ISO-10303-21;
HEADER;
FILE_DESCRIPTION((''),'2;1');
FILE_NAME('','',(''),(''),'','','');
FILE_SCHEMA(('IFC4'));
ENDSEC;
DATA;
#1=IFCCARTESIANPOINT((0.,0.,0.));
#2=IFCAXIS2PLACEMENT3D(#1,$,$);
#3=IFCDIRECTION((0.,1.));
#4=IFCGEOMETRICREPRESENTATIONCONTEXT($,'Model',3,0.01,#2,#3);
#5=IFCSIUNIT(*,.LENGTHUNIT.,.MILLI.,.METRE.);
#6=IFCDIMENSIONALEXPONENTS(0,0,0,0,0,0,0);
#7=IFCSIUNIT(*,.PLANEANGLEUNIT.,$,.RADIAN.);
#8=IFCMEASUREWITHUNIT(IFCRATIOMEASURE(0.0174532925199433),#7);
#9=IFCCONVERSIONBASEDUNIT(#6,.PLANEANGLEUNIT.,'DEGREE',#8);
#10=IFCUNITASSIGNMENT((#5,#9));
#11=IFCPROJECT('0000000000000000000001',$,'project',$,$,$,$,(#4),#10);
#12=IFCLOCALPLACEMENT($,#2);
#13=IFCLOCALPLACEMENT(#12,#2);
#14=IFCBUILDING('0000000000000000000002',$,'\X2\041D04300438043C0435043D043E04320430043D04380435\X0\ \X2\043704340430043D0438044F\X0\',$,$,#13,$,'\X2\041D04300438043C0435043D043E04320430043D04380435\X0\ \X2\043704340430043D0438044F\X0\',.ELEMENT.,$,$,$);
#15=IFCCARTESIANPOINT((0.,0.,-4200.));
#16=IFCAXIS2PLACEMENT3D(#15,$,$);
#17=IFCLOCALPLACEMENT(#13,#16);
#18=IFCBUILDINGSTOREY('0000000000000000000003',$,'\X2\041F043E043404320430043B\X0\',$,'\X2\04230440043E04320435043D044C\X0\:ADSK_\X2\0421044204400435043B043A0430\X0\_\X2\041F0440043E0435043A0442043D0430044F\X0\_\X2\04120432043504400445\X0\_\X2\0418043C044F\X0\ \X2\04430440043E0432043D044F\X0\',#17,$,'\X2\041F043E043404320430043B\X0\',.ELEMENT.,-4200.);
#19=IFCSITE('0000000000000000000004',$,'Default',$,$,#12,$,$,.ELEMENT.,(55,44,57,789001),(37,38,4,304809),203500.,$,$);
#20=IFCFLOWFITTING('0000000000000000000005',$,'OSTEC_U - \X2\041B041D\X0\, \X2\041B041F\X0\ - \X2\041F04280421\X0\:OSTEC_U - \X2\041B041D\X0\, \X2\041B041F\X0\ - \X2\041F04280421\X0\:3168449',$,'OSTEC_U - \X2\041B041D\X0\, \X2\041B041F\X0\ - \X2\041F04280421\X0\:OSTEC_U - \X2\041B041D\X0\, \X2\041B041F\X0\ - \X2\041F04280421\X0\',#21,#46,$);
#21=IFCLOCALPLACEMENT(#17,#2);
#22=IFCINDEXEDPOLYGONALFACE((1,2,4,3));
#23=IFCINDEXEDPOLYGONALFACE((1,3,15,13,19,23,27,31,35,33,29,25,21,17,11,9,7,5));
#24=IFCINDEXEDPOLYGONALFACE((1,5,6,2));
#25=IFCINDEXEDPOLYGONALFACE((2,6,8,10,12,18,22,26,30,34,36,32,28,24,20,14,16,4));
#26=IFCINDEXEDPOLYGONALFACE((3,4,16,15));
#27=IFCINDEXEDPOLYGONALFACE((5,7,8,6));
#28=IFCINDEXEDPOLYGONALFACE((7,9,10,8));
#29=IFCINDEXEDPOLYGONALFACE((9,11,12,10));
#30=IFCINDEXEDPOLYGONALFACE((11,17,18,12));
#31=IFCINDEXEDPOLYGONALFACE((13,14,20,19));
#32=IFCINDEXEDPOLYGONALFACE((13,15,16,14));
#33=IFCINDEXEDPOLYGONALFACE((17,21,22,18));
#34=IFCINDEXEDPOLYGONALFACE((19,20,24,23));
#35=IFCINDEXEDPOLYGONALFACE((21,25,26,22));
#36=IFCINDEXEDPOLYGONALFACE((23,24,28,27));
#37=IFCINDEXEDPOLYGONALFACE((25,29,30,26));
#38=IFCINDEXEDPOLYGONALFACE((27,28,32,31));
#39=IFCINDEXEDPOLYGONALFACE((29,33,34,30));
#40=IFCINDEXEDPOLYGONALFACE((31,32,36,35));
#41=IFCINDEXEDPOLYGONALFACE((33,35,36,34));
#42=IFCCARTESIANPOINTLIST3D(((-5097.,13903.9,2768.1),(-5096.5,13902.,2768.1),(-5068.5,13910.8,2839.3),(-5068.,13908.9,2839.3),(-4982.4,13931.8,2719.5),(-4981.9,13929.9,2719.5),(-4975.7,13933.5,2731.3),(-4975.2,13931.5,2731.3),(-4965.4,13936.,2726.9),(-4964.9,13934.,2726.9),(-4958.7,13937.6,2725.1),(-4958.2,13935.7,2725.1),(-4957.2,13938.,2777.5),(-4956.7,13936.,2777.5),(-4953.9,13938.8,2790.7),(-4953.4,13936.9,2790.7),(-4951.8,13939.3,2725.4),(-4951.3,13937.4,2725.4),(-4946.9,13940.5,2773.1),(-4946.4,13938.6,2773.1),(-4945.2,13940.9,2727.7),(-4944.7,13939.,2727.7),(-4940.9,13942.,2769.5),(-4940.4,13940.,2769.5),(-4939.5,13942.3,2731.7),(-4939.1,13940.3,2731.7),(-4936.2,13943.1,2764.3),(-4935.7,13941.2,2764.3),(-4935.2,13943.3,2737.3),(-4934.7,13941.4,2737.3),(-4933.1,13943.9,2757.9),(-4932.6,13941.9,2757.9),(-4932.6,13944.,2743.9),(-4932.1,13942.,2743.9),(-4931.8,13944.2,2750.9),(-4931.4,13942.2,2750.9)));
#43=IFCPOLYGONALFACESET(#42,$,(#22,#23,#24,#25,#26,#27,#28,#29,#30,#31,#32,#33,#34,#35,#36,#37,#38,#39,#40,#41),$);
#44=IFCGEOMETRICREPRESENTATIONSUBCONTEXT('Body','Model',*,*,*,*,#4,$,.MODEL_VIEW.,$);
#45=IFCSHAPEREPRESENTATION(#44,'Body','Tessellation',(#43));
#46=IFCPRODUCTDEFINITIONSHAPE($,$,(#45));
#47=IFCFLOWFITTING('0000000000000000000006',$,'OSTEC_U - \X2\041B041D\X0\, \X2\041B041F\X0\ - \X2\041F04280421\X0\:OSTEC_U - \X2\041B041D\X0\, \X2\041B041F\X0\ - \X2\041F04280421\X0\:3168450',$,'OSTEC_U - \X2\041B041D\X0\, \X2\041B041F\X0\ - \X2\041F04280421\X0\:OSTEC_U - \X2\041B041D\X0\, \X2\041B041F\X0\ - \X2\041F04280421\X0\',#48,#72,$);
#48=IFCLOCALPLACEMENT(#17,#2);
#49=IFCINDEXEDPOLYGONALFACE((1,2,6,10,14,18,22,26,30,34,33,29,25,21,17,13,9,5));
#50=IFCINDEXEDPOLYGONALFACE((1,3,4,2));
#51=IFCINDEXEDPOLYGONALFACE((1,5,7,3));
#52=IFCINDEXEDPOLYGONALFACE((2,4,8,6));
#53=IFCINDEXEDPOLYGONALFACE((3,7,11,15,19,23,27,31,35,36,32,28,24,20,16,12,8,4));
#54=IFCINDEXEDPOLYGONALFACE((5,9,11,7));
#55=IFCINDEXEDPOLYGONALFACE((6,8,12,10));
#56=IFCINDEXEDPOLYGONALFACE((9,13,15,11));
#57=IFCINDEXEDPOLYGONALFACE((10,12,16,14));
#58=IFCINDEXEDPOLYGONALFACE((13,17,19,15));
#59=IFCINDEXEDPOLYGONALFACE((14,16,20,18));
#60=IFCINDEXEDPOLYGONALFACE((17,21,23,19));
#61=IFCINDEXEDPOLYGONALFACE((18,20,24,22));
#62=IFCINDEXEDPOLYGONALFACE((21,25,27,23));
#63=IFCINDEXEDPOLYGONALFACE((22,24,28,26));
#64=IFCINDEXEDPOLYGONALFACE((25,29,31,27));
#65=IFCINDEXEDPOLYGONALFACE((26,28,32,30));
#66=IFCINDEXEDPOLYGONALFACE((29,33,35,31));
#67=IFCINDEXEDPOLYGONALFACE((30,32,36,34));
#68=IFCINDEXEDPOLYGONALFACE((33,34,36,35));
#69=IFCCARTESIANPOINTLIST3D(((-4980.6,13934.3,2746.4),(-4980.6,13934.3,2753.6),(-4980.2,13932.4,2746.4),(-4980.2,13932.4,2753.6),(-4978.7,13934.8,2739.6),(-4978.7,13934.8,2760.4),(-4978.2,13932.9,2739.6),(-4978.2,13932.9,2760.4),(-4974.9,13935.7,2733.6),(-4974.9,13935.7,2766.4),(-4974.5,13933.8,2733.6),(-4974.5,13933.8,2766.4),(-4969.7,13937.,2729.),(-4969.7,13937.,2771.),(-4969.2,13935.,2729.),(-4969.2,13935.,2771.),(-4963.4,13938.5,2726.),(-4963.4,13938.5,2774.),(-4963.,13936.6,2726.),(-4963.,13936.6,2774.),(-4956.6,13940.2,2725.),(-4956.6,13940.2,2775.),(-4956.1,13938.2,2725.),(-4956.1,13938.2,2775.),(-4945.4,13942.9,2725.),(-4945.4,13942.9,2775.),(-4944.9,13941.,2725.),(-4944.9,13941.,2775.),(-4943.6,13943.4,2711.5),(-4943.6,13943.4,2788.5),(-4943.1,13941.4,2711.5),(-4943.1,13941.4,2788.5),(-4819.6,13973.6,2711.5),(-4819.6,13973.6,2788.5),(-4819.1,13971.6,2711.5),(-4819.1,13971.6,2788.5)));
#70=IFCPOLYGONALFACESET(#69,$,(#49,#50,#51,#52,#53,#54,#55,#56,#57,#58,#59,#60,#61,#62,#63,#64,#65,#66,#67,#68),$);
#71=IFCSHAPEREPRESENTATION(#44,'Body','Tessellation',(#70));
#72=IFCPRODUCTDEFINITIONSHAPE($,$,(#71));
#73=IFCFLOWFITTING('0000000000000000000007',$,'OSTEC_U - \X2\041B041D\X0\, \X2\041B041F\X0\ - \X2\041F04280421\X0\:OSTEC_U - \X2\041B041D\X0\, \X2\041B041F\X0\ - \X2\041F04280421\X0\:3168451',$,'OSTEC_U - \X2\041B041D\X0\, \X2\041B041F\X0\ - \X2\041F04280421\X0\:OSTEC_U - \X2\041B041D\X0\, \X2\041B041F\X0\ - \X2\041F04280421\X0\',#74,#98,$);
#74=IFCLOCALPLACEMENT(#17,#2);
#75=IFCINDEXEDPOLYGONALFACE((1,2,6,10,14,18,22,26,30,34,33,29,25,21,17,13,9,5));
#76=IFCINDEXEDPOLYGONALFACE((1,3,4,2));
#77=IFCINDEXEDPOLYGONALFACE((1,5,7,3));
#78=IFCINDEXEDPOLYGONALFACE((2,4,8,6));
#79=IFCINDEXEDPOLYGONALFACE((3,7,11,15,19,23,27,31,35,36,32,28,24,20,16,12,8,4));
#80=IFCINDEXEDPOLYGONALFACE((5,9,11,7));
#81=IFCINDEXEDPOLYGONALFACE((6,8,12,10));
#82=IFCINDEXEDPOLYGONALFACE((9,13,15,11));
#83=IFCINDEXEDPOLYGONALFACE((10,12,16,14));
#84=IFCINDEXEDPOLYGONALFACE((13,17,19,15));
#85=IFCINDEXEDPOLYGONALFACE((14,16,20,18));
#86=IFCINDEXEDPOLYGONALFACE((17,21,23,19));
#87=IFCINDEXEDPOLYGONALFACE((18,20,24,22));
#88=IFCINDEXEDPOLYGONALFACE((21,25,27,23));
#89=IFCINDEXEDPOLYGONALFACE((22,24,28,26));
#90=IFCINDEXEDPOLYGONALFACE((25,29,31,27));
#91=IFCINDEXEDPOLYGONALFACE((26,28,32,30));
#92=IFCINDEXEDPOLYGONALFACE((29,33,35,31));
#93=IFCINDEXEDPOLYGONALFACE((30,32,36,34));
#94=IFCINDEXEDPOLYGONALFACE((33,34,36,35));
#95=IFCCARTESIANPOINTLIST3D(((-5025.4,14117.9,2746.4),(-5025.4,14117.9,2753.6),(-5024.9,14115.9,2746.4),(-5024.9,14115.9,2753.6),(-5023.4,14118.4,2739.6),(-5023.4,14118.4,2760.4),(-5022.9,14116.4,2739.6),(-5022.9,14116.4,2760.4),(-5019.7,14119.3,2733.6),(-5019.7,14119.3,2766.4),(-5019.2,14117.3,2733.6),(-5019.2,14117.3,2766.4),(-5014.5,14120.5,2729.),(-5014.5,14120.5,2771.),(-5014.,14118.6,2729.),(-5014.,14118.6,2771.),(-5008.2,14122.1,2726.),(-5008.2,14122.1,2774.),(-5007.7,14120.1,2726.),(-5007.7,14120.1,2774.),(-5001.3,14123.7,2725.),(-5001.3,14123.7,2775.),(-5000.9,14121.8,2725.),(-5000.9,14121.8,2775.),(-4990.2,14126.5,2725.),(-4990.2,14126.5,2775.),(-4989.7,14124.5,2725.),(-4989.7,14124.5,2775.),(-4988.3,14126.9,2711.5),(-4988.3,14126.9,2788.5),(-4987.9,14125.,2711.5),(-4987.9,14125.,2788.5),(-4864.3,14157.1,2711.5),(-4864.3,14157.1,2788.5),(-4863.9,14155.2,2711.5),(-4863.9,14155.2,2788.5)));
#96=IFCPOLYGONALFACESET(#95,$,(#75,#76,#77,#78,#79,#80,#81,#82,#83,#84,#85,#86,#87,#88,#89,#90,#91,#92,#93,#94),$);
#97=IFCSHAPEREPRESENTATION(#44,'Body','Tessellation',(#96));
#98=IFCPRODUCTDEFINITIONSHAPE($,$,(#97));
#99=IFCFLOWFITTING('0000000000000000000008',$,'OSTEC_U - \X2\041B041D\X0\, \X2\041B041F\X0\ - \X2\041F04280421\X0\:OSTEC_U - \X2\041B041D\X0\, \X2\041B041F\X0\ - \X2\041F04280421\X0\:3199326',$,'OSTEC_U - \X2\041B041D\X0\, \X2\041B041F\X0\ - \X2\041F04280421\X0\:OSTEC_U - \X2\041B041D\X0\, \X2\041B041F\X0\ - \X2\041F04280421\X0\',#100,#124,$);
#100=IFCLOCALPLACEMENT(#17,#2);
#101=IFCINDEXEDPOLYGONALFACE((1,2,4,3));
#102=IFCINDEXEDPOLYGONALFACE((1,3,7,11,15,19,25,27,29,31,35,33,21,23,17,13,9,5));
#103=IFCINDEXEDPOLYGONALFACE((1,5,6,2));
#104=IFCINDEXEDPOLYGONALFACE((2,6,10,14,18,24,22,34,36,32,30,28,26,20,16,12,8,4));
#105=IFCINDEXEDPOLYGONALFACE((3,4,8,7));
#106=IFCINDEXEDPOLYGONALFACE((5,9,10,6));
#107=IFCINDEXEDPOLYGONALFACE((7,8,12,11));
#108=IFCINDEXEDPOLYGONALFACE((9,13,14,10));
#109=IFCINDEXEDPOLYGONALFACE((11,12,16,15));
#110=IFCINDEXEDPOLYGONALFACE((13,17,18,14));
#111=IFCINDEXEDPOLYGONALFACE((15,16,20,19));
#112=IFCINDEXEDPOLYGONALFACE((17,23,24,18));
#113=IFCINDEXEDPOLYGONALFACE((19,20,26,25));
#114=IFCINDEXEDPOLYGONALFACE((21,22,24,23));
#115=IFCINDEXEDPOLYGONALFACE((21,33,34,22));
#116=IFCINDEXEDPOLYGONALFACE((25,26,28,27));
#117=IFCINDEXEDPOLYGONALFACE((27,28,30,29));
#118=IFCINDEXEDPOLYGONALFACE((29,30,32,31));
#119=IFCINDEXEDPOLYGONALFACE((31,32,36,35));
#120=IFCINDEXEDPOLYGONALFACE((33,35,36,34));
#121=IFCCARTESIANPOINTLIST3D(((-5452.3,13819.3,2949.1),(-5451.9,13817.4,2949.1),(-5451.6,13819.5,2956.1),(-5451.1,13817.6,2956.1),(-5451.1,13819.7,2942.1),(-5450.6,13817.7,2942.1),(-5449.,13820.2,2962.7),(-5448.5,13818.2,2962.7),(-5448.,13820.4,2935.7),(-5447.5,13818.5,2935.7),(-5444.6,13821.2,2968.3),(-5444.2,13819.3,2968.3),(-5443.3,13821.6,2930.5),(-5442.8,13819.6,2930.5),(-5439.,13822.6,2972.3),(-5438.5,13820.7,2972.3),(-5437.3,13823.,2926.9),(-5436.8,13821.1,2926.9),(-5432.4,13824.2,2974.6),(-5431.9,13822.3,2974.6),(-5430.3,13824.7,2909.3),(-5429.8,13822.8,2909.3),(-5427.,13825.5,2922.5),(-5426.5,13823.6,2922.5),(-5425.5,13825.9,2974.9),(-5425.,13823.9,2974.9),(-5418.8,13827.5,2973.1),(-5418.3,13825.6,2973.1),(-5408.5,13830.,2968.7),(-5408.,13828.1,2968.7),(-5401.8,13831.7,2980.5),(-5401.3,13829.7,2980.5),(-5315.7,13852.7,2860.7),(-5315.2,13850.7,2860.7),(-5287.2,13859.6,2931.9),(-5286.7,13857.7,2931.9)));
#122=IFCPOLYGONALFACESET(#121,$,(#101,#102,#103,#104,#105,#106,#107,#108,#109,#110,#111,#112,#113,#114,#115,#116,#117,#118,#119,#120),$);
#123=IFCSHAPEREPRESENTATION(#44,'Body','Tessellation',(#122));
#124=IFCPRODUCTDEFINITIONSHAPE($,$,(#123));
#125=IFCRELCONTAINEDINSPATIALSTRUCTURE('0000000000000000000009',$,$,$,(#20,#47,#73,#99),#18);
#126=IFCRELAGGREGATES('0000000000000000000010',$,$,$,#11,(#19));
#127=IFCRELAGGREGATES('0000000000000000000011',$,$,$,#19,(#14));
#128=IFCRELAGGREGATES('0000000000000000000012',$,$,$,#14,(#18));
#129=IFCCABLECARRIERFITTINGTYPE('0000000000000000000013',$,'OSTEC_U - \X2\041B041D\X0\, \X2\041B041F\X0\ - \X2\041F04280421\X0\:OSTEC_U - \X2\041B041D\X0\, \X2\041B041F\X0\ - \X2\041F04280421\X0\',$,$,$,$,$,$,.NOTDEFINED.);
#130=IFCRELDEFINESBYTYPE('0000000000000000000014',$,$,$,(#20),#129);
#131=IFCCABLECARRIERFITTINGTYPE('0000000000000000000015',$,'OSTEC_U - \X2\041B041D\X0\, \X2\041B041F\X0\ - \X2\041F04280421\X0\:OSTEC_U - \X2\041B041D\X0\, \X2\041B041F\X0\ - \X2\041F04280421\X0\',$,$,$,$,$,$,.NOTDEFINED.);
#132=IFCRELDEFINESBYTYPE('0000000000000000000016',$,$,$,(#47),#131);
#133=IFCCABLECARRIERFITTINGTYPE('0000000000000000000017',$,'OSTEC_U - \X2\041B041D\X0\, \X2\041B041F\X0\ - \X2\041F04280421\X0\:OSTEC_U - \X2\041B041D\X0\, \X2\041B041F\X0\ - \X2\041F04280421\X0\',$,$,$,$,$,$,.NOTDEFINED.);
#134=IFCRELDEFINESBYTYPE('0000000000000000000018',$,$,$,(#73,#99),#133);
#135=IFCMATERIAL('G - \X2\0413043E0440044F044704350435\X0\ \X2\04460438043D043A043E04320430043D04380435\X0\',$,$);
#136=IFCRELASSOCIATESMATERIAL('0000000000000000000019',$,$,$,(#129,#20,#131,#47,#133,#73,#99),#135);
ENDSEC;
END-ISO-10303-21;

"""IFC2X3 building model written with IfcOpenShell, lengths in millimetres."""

from ifc_helpers import new_model, entity, si_unit, converted_unit, direction, frame, frame_2d, origin, place, context, subcontext, project, spatial, polyline, circle_curve, parameter, trimmed, segment, composite_curve, outline, extrude, source, transform, mapped, material, type_object, type_shapes, element, save


model = new_model("IFC2X3")

# Units and contexts
model_context = context("Model", 3, precision=0.01, world=origin(), true_north=direction((0.0, 1.0)))
body_context = subcontext(model_context, "Body", "Model", "MODEL_VIEW")
ifc_project = project(units=[si_unit("LENGTHUNIT", "METRE", prefix="MILLI"), converted_unit("PLANEANGLEUNIT", "DEGREE", entity("IfcRatioMeasure", 0.0174532925199433), si_unit("PLANEANGLEUNIT", "RADIAN"), dimensions=[0, 0, 0, 0, 0, 0, 0])], contexts=[model_context])

# Site, building, storey
site_placement = place(None, frame((0.0, 0.0, 0.0)))
site = spatial("IfcSite", under=ifc_project, at=site_placement, Name="Default", CompositionType="ELEMENT", RefLatitude=(55, 44, 57, 789001), RefLongitude=(37, 38, 4, 304809), RefElevation=203500.0)
building_placement = place(site_placement, origin())
building = spatial("IfcBuilding", under=site, at=building_placement, Name="Наименование здания", LongName="Наименование здания", CompositionType="ELEMENT")
storey_placement = place(building_placement, frame((0.0, 0.0, -4200.0)))
storey = spatial("IfcBuildingStorey", under=building, at=storey_placement, Name="Подвал", ObjectType="Уровень:ADSK_Стрелка_Проектная_Вверх_Имя уровня", LongName="Подвал", CompositionType="ELEMENT", Elevation=-4200.0)

# Flow fittings
ifc_material = material(Name="G - Горячее цинкование")
cable_carrier_fitting_type_1 = type_object("IfcCableCarrierFittingType", Name="OSTEC_U - ЛН, ЛП - ПШС:OSTEC_U - ЛН, ЛП - ПШС", PredefinedType="NOTDEFINED", material=ifc_material)
shared_shape_1 = source(origin(), body_context, "Body", "SweptSolid", [
    extrude(outline(composite_curve([segment(trimmed(circle_curve(frame_2d((-41.5, 0.0), x_axis=(1.0, 0.0)), 25.0), [parameter(90.0)], [parameter(270.0)], True, "PARAMETER"), True, "CONTINUOUS"), segment(polyline([(-41.5, -25.0), (-30.0, -25.0)]), True, "CONTINUOUS"), segment(polyline([(-30.0, -25.0), (-28.1, -38.5)]), True, "CONTINUOUS"), segment(polyline([(-28.1, -38.5), (99.5, -38.5)]), True, "CONTINUOUS"), segment(polyline([(99.5, -38.5), (99.5, 38.5)]), True, "CONTINUOUS"), segment(polyline([(99.5, 38.5), (-28.1, 38.5)]), True, "CONTINUOUS"), segment(polyline([(-28.1, 38.5), (-30.0, 25.0)]), True, "CONTINUOUS"), segment(polyline([(-30.0, 25.0), (-41.5, 25.0)]), True, "CONTINUOUS")], self_intersect=False)), frame((41.5, 0.0, 0.0)), (0.0, 0.0, 1.0), 2.0),
])
type_shapes(cable_carrier_fitting_type_1, [shared_shape_1])
flow_fitting_1_placement = place(storey_placement, frame((-4956.1, 13938.2, 2750.0), z_axis=(0.236821, -0.971553, 0.0), x_axis=(-0.898257, -0.218954, 0.381042)))
element("IfcFlowFitting", 1, at=flow_fitting_1_placement, inside=storey, type_object=cable_carrier_fitting_type_1, material=ifc_material, Name="OSTEC_U - ЛН, ЛП - ПШС:OSTEC_U - ЛН, ЛП - ПШС:3168449", ObjectType="OSTEC_U - ЛН, ЛП - ПШС:OSTEC_U - ЛН, ЛП - ПШС", context=body_context, shape_type="MappedRepresentation", body=[
    mapped(shared_shape_1, transform((0.0, 0.0, 0.0), scale=1.0)),
])
cable_carrier_fitting_type_2 = type_object("IfcCableCarrierFittingType", Name="OSTEC_U - ЛН, ЛП - ПШС:OSTEC_U - ЛН, ЛП - ПШС", PredefinedType="NOTDEFINED", material=ifc_material)
shared_shape_2 = source(origin(), body_context, "Body", "SweptSolid", [
    extrude(outline(composite_curve([segment(trimmed(circle_curve(frame_2d((-41.5, 0.0), x_axis=(1.0, 0.0)), 25.0), [parameter(90.0)], [parameter(270.0)], True, "PARAMETER"), True, "CONTINUOUS"), segment(polyline([(-41.5, -25.0), (-30.0, -25.0)]), True, "CONTINUOUS"), segment(polyline([(-30.0, -25.0), (-28.1, -38.5)]), True, "CONTINUOUS"), segment(polyline([(-28.1, -38.5), (99.5, -38.5)]), True, "CONTINUOUS"), segment(polyline([(99.5, -38.5), (99.5, 38.5)]), True, "CONTINUOUS"), segment(polyline([(99.5, 38.5), (-28.1, 38.5)]), True, "CONTINUOUS"), segment(polyline([(-28.1, 38.5), (-30.0, 25.0)]), True, "CONTINUOUS"), segment(polyline([(-30.0, 25.0), (-41.5, 25.0)]), True, "CONTINUOUS")], self_intersect=False)), frame((41.5, 0.0, 0.0), z_axis=(0.0, 0.0, -1.0), x_axis=(1.0, 0.0, 0.0)), (0.0, 0.0, -1.0), 2.0),
])
type_shapes(cable_carrier_fitting_type_2, [shared_shape_2])
flow_fitting_2_placement = place(storey_placement, frame((-4956.6, 13940.2, 2750.0), z_axis=(0.236821, -0.971553, 0.0), x_axis=(0.971553, 0.236821, 0.0)))
element("IfcFlowFitting", 2, at=flow_fitting_2_placement, inside=storey, type_object=cable_carrier_fitting_type_2, material=ifc_material, Name="OSTEC_U - ЛН, ЛП - ПШС:OSTEC_U - ЛН, ЛП - ПШС:3168450", ObjectType="OSTEC_U - ЛН, ЛП - ПШС:OSTEC_U - ЛН, ЛП - ПШС", context=body_context, shape_type="MappedRepresentation", body=[
    mapped(shared_shape_2, transform((0.0, 0.0, 0.0), scale=1.0)),
])
cable_carrier_fitting_type_3 = type_object("IfcCableCarrierFittingType", Name="OSTEC_U - ЛН, ЛП - ПШС:OSTEC_U - ЛН, ЛП - ПШС", PredefinedType="NOTDEFINED", material=ifc_material)
shared_shape_3 = source(origin(), body_context, "Body", "SweptSolid", [
    extrude(outline(composite_curve([segment(trimmed(circle_curve(frame_2d((-41.5, 0.0), x_axis=(1.0, 0.0)), 25.0), [parameter(90.0)], [parameter(270.0)], True, "PARAMETER"), True, "CONTINUOUS"), segment(polyline([(-41.5, -25.0), (-30.0, -25.0)]), True, "CONTINUOUS"), segment(polyline([(-30.0, -25.0), (-28.1, -38.5)]), True, "CONTINUOUS"), segment(polyline([(-28.1, -38.5), (99.5, -38.5)]), True, "CONTINUOUS"), segment(polyline([(99.5, -38.5), (99.5, 38.5)]), True, "CONTINUOUS"), segment(polyline([(99.5, 38.5), (-28.1, 38.5)]), True, "CONTINUOUS"), segment(polyline([(-28.1, 38.5), (-30.0, 25.0)]), True, "CONTINUOUS"), segment(polyline([(-30.0, 25.0), (-41.5, 25.0)]), True, "CONTINUOUS")], self_intersect=False)), frame((41.5, 0.0, 0.0)), (0.0, 0.0, 1.0), 2.0),
])
type_shapes(cable_carrier_fitting_type_3, [shared_shape_3])
for number, where, z_axis, x_axis, name in (
    (3, (-5000.9, 14121.8, 2750.0), (-0.236821, 0.971553, 0.0), (0.971553, 0.236821, 0.0), "OSTEC_U - ЛН, ЛП - ПШС:OSTEC_U - ЛН, ЛП - ПШС:3168451"),
    (4, (-5428.1, 13825.3, 2950.0), (0.236821, -0.971553, 0.0), (0.898257, 0.218954, -0.381042), "OSTEC_U - ЛН, ЛП - ПШС:OSTEC_U - ЛН, ЛП - ПШС:3199326"),
):
    element("IfcFlowFitting", number, at=place(storey_placement, frame(where, z_axis=z_axis, x_axis=x_axis)), inside=storey, type_object=cable_carrier_fitting_type_3, material=ifc_material, Name=name, ObjectType="OSTEC_U - ЛН, ЛП - ПШС:OSTEC_U - ЛН, ЛП - ПШС", context=body_context, shape_type="MappedRepresentation", body=[
        mapped(shared_shape_3, transform((0.0, 0.0, 0.0), scale=1.0)),
    ])

save(model, "model.ifc")
